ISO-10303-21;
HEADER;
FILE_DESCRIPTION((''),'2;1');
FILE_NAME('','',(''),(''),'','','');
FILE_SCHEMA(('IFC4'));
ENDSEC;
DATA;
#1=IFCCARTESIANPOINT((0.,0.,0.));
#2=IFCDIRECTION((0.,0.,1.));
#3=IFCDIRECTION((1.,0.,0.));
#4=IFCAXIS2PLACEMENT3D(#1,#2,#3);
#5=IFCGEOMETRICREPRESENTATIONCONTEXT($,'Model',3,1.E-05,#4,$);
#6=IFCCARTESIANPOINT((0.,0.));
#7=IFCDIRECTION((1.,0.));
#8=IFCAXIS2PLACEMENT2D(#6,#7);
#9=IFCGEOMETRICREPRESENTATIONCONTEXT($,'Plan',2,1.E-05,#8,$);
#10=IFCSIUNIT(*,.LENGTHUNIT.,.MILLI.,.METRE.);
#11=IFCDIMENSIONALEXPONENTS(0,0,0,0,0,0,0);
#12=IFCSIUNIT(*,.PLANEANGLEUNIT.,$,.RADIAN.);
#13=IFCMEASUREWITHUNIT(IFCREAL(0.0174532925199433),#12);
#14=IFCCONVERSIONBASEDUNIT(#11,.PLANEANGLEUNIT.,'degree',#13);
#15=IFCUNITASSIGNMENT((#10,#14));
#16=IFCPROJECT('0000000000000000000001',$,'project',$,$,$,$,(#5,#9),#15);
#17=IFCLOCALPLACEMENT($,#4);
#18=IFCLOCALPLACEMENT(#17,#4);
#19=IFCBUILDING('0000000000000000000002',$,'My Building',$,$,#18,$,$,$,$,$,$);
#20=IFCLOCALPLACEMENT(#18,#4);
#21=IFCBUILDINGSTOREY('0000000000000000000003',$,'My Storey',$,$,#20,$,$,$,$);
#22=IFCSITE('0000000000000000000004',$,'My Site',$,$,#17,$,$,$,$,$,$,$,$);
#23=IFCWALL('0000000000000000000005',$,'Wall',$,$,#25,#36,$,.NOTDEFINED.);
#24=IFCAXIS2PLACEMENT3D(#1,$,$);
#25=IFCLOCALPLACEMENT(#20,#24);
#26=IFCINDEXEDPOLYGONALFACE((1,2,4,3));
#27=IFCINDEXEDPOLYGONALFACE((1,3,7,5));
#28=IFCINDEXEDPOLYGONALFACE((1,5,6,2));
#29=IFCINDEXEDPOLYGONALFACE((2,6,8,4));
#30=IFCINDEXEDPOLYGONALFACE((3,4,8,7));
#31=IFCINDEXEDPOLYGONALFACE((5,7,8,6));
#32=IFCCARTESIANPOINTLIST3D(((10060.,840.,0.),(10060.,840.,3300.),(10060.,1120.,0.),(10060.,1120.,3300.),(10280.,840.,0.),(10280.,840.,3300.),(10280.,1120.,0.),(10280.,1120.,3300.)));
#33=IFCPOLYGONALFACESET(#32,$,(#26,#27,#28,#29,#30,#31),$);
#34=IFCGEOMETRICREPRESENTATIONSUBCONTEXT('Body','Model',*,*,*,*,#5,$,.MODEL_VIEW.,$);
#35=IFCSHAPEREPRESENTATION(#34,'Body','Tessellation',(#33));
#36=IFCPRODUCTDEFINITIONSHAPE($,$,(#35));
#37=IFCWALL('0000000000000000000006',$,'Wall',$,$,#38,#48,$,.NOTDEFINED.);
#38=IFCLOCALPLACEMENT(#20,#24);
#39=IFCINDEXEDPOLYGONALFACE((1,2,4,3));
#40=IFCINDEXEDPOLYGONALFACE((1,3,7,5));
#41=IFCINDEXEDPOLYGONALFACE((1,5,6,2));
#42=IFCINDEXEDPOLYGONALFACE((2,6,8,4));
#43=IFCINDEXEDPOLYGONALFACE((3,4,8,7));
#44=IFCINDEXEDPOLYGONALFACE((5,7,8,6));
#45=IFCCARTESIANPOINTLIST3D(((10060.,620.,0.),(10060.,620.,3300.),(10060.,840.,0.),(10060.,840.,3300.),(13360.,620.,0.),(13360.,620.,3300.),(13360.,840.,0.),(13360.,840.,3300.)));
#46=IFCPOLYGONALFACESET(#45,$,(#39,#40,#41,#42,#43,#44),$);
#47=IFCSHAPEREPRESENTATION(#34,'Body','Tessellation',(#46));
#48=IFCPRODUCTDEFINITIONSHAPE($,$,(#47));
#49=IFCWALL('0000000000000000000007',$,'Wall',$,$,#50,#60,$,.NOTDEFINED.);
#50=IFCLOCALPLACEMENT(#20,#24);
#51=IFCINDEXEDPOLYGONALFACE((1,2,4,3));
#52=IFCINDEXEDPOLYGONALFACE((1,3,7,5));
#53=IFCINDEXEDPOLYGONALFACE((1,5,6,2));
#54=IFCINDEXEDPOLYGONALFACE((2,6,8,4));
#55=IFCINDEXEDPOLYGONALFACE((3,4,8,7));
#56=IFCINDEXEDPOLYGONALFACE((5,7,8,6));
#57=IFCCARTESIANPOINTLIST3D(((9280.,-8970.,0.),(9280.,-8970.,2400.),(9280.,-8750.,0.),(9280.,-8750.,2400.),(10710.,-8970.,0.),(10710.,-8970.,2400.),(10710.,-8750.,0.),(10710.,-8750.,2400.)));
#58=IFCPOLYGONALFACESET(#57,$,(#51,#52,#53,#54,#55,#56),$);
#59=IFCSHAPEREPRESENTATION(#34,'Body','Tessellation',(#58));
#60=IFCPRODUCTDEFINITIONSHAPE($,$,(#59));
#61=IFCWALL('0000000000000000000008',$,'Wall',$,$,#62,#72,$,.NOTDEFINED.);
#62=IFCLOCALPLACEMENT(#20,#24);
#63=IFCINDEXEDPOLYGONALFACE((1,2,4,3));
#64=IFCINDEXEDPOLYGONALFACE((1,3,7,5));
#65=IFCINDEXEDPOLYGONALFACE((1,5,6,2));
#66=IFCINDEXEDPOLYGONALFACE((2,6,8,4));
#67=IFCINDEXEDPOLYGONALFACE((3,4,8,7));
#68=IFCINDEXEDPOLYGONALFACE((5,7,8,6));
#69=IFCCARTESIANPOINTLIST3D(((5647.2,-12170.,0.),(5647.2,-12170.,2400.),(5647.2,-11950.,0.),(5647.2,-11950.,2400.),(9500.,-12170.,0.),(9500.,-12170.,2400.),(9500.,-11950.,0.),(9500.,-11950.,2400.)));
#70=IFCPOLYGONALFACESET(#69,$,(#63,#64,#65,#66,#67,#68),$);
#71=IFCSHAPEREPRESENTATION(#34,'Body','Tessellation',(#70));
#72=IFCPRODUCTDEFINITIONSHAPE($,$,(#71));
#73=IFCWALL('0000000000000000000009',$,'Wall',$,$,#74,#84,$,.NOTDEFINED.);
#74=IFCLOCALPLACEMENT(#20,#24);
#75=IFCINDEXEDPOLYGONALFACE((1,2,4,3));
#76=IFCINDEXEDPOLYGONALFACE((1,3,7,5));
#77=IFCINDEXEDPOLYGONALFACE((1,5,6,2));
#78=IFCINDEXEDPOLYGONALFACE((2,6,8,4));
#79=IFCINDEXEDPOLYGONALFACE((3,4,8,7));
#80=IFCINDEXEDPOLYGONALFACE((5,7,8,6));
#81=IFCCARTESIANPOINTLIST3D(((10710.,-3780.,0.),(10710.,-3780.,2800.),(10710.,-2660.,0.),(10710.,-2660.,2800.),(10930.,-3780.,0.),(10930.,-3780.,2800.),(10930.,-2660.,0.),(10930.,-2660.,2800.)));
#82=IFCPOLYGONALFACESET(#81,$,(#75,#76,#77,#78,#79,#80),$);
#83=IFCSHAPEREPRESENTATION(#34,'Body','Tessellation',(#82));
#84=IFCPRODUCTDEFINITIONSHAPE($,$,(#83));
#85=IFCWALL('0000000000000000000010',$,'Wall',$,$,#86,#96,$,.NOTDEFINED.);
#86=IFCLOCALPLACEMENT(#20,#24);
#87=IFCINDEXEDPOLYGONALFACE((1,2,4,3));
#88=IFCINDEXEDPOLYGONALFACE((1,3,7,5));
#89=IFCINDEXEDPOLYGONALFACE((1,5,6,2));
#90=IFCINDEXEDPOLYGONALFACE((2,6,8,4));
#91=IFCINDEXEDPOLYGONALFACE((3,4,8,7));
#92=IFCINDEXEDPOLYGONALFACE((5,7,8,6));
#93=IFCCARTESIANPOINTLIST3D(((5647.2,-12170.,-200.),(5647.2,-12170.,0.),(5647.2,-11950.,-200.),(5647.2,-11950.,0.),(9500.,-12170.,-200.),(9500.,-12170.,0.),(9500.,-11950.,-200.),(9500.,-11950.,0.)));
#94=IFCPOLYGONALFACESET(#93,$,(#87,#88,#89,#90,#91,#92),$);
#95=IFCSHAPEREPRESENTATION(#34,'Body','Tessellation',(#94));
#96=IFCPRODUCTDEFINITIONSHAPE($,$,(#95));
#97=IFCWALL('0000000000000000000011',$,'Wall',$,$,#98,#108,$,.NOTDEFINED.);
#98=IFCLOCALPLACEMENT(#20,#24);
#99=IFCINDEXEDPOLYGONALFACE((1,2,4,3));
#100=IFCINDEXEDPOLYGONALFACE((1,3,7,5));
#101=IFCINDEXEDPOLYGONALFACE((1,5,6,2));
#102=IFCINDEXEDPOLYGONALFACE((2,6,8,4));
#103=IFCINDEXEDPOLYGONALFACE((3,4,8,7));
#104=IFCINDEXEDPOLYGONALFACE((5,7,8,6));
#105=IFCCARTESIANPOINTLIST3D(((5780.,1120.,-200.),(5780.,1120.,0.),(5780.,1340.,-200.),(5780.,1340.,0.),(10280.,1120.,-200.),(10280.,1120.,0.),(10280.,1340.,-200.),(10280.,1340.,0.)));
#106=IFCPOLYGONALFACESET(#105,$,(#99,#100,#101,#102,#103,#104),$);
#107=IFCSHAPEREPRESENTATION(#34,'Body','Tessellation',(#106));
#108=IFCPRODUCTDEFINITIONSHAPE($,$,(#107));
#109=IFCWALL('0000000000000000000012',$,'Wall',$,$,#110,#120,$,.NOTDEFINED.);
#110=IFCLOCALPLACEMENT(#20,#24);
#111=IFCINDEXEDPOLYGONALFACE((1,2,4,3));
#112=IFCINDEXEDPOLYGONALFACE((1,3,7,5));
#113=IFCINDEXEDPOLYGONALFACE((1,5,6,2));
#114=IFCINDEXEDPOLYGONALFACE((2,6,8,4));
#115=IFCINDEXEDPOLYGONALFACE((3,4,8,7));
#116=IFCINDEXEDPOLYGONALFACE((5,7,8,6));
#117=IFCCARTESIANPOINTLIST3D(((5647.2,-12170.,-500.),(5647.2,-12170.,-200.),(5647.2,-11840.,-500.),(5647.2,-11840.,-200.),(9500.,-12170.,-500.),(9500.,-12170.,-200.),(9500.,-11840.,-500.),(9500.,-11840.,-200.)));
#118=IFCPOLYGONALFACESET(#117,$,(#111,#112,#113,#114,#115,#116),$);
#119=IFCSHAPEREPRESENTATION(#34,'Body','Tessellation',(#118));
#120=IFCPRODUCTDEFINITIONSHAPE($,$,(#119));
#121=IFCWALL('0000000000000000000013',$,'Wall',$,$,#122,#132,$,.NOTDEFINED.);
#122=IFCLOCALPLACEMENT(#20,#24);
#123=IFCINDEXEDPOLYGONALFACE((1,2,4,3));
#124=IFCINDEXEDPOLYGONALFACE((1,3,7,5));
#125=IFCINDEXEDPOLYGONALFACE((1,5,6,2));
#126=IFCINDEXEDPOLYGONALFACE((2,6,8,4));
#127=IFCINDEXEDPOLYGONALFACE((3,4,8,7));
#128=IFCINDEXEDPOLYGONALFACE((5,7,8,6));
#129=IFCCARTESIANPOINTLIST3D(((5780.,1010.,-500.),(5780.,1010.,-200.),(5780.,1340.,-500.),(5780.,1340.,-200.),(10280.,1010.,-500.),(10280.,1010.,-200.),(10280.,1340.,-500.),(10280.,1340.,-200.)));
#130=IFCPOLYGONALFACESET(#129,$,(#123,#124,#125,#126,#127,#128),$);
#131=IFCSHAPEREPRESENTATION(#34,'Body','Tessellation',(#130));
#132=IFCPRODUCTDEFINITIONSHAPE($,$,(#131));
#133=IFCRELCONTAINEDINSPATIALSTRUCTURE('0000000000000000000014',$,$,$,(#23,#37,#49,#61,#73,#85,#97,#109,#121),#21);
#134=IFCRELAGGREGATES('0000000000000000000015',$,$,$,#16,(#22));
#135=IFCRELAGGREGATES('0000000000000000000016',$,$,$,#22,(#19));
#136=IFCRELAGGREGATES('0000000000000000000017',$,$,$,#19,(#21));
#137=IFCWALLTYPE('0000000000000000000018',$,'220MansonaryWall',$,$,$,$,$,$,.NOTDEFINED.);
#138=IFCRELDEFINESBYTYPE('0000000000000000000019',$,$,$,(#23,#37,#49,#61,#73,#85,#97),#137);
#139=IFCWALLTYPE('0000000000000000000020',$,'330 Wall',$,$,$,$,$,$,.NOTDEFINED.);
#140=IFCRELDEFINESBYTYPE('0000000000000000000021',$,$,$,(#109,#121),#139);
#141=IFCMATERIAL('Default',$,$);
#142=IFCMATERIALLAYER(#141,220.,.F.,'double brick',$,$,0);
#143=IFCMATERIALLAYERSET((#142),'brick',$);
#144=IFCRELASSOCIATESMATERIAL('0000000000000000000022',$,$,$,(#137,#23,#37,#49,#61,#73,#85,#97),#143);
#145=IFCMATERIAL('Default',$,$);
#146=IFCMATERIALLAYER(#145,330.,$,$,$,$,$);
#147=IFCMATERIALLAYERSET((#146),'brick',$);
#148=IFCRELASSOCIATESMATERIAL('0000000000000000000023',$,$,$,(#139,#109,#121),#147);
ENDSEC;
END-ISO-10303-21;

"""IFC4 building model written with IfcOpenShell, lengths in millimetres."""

from ifc_helpers import new_model, entity, si_unit, converted_unit, frame, origin_with_axes, origin_2d_with_axis, place, context, subcontext, project, spatial, indexed_curve, outline, extrude, material, layer, layer_set, layer_usage, type_object, element, save


model = new_model("IFC4")

# Units and contexts
model_context = context("Model", 3, precision=1e-05, world=origin_with_axes())
plan_context = context("Plan", 2, precision=1e-05, world=origin_2d_with_axis())
body_context_1 = subcontext(model_context, "Body", "Model", "MODEL_VIEW")
ifc_project = project(units=[si_unit("LENGTHUNIT", "METRE", prefix="MILLI"), converted_unit("PLANEANGLEUNIT", "degree", entity("IfcReal", 0.0174532925199433), si_unit("PLANEANGLEUNIT", "RADIAN"), dimensions=[0, 0, 0, 0, 0, 0, 0])], contexts=[model_context, plan_context])

# Site, building, storey
site_placement = place(None, origin_with_axes())
site = spatial("IfcSite", under=ifc_project, at=site_placement, Name="My Site")
building_placement = place(site_placement, origin_with_axes())
building = spatial("IfcBuilding", under=site, at=building_placement, Name="My Building")
storey_placement = place(building_placement, origin_with_axes())
storey = spatial("IfcBuildingStorey", under=building, at=storey_placement, Name="My Storey")

# Shared definitions
ifc_material_1 = material(Name="Default")
ifc_layer_1 = layer(ifc_material_1, 220.0, ventilated=False, Name="double brick", Priority=0)
ifc_layer_set_1 = layer_set([ifc_layer_1], Name="brick")
wall_type_1 = type_object("IfcWallType", Name="220MansonaryWall", PredefinedType="NOTDEFINED", material=ifc_layer_set_1)

# Walls
ifc_layer_usage_1 = layer_usage(ifc_layer_set_1, "AXIS2", "POSITIVE", 0.0)
wall_1_placement = place(storey_placement, frame((10060.0, 1120.0, 0.0), z_axis=(0.0, 0.0, 1.0), x_axis=(-0.000001, -1.0, 0.0)))
element("IfcWall", 1, at=wall_1_placement, inside=storey, type_object=wall_type_1, material=ifc_layer_usage_1, Name="Wall", PredefinedType="NOTDEFINED", context=body_context_1, shape_type="SweptSolid", body=[
    extrude(outline(indexed_curve([(0.0, 0.0), (0.0, 220.0), (280.0, 220.0), (280.0, 0.0), (0.0, 0.0)], self_intersect=False)), origin_with_axes(), (0.0, 0.0, 1.0), 3300.0),
])
ifc_layer_usage_2 = layer_usage(ifc_layer_set_1, "AXIS2", "POSITIVE", 0.0)
wall_2_placement = place(storey_placement, frame((10060.0, 620.0, 0.0), z_axis=(0.0, 0.0, 1.0), x_axis=(1.0, -0.000001, 0.0)))
element("IfcWall", 2, at=wall_2_placement, inside=storey, type_object=wall_type_1, material=ifc_layer_usage_2, Name="Wall", PredefinedType="NOTDEFINED", context=body_context_1, shape_type="SweptSolid", body=[
    extrude(outline(indexed_curve([(0.0, 0.0), (0.0, 220.0), (3300.0, 220.0), (3300.0, 0.0), (0.0, 0.0)], self_intersect=False)), origin_with_axes(), (0.0, 0.0, 1.0), 3300.0),
])

# Walls
ifc_layer_usage_3 = layer_usage(ifc_layer_set_1, "AXIS2", "POSITIVE", 0.0)
wall_3_placement = place(storey_placement, frame((10710.0, -8750.0, 0.0), z_axis=(0.0, 0.0, 1.0), x_axis=(-1.0, 0.0, 0.0)))
element("IfcWall", 3, at=wall_3_placement, inside=storey, type_object=wall_type_1, material=ifc_layer_usage_3, Name="Wall", PredefinedType="NOTDEFINED", context=body_context_1, shape_type="SweptSolid", body=[
    extrude(outline(indexed_curve([(0.0, 0.0), (0.0, 220.0), (1430.0, 220.0), (1430.0, 0.0), (0.0, 0.0)], self_intersect=False)), origin_with_axes(), (0.0, 0.0, 1.0), 2400.0),
])
ifc_layer_usage_4 = layer_usage(ifc_layer_set_1, "AXIS2", "POSITIVE", 0.0)
wall_4_placement = place(storey_placement, frame((9500.0, -11950.0, 0.0), z_axis=(0.0, 0.0, 1.0), x_axis=(-1.0, 0.000001, 0.0)))
element("IfcWall", 4, at=wall_4_placement, inside=storey, type_object=wall_type_1, material=ifc_layer_usage_4, Name="Wall", PredefinedType="NOTDEFINED", context=body_context_1, shape_type="SweptSolid", body=[
    extrude(outline(indexed_curve([(0.0, 0.0), (0.0, 220.0), (3852.8, 220.0), (3852.8, 0.0), (0.0, 0.0)], self_intersect=False)), origin_with_axes(), (0.0, 0.0, 1.0), 2400.0),
])
ifc_layer_usage_5 = layer_usage(ifc_layer_set_1, "AXIS2", "POSITIVE", 0.0)
wall_5_placement = place(storey_placement, frame((10930.0, -3780.0, 0.0), z_axis=(0.0, 0.0, 1.0), x_axis=(0.0, 1.0, 0.0)))
element("IfcWall", 5, at=wall_5_placement, inside=storey, type_object=wall_type_1, material=ifc_layer_usage_5, Name="Wall", PredefinedType="NOTDEFINED", context=body_context_1, shape_type="SweptSolid", body=[
    extrude(outline(indexed_curve([(0.0, 0.0), (0.0, 220.0), (1120.0, 220.0), (1120.0, 0.0), (0.0, 0.0)], self_intersect=False)), origin_with_axes(), (0.0, 0.0, 1.0), 2800.0),
])
ifc_layer_usage_6 = layer_usage(ifc_layer_set_1, "AXIS2", "POSITIVE", 0.0)
wall_6_placement = place(storey_placement, frame((5647.2, -12170.0, -200.0), z_axis=(0.0, 0.0, 1.0), x_axis=(1.0, 0.0, 0.0)))
element("IfcWall", 6, at=wall_6_placement, inside=storey, type_object=wall_type_1, material=ifc_layer_usage_6, Name="Wall", PredefinedType="NOTDEFINED", context=body_context_1, shape_type="SweptSolid", body=[
    extrude(outline(indexed_curve([(0.0, 0.0), (0.0, 220.0), (3852.8, 220.0), (3852.8, 0.0), (0.0, 0.0)], self_intersect=False)), origin_with_axes(), (0.0, 0.0, 1.0), 200.0),
])
ifc_layer_usage_7 = layer_usage(ifc_layer_set_1, "AXIS2", "POSITIVE", 0.0)
wall_7_placement = place(storey_placement, frame((10280.0, 1340.0, -200.0), z_axis=(0.0, 0.0, 1.0), x_axis=(-1.0, 0.0, 0.0)))
element("IfcWall", 7, at=wall_7_placement, inside=storey, type_object=wall_type_1, material=ifc_layer_usage_7, Name="Wall", PredefinedType="NOTDEFINED", context=body_context_1, shape_type="SweptSolid", body=[
    extrude(outline(indexed_curve([(0.0, 0.0), (0.0, 220.0), (4500.0, 220.0), (4500.0, 0.0), (0.0, 0.0)], self_intersect=False)), origin_with_axes(), (0.0, 0.0, 1.0), 200.0),
])
ifc_material_2 = material(Name="Default")
ifc_layer_2 = layer(ifc_material_2, 330.0)
ifc_layer_set_2 = layer_set([ifc_layer_2], Name="brick")
ifc_layer_usage_8 = layer_usage(ifc_layer_set_2, "AXIS2", "POSITIVE", 0.0)
wall_type_2 = type_object("IfcWallType", Name="330 Wall", PredefinedType="NOTDEFINED", material=ifc_layer_set_2)
wall_8_placement = place(storey_placement, frame((5647.2, -12170.0, -500.0), z_axis=(0.0, 0.0, 1.0), x_axis=(1.0, 0.0, 0.0)))
element("IfcWall", 8, at=wall_8_placement, inside=storey, type_object=wall_type_2, material=ifc_layer_usage_8, Name="Wall", PredefinedType="NOTDEFINED", context=body_context_1, shape_type="SweptSolid", body=[
    extrude(outline(indexed_curve([(0.0, 0.0), (0.0, 330.0), (3852.8, 330.0), (3852.8, 0.0), (0.0, 0.0)], self_intersect=False)), origin_with_axes(), (0.0, 0.0, 1.0), 300.0),
])
ifc_layer_usage_9 = layer_usage(ifc_layer_set_2, "AXIS2", "POSITIVE", 0.0)
wall_9_placement = place(storey_placement, frame((5780.0, 1010.0, -500.0), z_axis=(0.0, 0.0, 1.0), x_axis=(1.0, 0.0, 0.0)))
element("IfcWall", 9, at=wall_9_placement, inside=storey, type_object=wall_type_2, material=ifc_layer_usage_9, Name="Wall", PredefinedType="NOTDEFINED", context=body_context_1, shape_type="SweptSolid", body=[
    extrude(outline(indexed_curve([(0.0, 0.0), (0.0, 330.0), (4500.0, 330.0), (4500.0, 0.0), (0.0, 0.0)], self_intersect=False)), origin_with_axes(), (0.0, 0.0, 1.0), 300.0),
])

save(model, "model.ifc")
